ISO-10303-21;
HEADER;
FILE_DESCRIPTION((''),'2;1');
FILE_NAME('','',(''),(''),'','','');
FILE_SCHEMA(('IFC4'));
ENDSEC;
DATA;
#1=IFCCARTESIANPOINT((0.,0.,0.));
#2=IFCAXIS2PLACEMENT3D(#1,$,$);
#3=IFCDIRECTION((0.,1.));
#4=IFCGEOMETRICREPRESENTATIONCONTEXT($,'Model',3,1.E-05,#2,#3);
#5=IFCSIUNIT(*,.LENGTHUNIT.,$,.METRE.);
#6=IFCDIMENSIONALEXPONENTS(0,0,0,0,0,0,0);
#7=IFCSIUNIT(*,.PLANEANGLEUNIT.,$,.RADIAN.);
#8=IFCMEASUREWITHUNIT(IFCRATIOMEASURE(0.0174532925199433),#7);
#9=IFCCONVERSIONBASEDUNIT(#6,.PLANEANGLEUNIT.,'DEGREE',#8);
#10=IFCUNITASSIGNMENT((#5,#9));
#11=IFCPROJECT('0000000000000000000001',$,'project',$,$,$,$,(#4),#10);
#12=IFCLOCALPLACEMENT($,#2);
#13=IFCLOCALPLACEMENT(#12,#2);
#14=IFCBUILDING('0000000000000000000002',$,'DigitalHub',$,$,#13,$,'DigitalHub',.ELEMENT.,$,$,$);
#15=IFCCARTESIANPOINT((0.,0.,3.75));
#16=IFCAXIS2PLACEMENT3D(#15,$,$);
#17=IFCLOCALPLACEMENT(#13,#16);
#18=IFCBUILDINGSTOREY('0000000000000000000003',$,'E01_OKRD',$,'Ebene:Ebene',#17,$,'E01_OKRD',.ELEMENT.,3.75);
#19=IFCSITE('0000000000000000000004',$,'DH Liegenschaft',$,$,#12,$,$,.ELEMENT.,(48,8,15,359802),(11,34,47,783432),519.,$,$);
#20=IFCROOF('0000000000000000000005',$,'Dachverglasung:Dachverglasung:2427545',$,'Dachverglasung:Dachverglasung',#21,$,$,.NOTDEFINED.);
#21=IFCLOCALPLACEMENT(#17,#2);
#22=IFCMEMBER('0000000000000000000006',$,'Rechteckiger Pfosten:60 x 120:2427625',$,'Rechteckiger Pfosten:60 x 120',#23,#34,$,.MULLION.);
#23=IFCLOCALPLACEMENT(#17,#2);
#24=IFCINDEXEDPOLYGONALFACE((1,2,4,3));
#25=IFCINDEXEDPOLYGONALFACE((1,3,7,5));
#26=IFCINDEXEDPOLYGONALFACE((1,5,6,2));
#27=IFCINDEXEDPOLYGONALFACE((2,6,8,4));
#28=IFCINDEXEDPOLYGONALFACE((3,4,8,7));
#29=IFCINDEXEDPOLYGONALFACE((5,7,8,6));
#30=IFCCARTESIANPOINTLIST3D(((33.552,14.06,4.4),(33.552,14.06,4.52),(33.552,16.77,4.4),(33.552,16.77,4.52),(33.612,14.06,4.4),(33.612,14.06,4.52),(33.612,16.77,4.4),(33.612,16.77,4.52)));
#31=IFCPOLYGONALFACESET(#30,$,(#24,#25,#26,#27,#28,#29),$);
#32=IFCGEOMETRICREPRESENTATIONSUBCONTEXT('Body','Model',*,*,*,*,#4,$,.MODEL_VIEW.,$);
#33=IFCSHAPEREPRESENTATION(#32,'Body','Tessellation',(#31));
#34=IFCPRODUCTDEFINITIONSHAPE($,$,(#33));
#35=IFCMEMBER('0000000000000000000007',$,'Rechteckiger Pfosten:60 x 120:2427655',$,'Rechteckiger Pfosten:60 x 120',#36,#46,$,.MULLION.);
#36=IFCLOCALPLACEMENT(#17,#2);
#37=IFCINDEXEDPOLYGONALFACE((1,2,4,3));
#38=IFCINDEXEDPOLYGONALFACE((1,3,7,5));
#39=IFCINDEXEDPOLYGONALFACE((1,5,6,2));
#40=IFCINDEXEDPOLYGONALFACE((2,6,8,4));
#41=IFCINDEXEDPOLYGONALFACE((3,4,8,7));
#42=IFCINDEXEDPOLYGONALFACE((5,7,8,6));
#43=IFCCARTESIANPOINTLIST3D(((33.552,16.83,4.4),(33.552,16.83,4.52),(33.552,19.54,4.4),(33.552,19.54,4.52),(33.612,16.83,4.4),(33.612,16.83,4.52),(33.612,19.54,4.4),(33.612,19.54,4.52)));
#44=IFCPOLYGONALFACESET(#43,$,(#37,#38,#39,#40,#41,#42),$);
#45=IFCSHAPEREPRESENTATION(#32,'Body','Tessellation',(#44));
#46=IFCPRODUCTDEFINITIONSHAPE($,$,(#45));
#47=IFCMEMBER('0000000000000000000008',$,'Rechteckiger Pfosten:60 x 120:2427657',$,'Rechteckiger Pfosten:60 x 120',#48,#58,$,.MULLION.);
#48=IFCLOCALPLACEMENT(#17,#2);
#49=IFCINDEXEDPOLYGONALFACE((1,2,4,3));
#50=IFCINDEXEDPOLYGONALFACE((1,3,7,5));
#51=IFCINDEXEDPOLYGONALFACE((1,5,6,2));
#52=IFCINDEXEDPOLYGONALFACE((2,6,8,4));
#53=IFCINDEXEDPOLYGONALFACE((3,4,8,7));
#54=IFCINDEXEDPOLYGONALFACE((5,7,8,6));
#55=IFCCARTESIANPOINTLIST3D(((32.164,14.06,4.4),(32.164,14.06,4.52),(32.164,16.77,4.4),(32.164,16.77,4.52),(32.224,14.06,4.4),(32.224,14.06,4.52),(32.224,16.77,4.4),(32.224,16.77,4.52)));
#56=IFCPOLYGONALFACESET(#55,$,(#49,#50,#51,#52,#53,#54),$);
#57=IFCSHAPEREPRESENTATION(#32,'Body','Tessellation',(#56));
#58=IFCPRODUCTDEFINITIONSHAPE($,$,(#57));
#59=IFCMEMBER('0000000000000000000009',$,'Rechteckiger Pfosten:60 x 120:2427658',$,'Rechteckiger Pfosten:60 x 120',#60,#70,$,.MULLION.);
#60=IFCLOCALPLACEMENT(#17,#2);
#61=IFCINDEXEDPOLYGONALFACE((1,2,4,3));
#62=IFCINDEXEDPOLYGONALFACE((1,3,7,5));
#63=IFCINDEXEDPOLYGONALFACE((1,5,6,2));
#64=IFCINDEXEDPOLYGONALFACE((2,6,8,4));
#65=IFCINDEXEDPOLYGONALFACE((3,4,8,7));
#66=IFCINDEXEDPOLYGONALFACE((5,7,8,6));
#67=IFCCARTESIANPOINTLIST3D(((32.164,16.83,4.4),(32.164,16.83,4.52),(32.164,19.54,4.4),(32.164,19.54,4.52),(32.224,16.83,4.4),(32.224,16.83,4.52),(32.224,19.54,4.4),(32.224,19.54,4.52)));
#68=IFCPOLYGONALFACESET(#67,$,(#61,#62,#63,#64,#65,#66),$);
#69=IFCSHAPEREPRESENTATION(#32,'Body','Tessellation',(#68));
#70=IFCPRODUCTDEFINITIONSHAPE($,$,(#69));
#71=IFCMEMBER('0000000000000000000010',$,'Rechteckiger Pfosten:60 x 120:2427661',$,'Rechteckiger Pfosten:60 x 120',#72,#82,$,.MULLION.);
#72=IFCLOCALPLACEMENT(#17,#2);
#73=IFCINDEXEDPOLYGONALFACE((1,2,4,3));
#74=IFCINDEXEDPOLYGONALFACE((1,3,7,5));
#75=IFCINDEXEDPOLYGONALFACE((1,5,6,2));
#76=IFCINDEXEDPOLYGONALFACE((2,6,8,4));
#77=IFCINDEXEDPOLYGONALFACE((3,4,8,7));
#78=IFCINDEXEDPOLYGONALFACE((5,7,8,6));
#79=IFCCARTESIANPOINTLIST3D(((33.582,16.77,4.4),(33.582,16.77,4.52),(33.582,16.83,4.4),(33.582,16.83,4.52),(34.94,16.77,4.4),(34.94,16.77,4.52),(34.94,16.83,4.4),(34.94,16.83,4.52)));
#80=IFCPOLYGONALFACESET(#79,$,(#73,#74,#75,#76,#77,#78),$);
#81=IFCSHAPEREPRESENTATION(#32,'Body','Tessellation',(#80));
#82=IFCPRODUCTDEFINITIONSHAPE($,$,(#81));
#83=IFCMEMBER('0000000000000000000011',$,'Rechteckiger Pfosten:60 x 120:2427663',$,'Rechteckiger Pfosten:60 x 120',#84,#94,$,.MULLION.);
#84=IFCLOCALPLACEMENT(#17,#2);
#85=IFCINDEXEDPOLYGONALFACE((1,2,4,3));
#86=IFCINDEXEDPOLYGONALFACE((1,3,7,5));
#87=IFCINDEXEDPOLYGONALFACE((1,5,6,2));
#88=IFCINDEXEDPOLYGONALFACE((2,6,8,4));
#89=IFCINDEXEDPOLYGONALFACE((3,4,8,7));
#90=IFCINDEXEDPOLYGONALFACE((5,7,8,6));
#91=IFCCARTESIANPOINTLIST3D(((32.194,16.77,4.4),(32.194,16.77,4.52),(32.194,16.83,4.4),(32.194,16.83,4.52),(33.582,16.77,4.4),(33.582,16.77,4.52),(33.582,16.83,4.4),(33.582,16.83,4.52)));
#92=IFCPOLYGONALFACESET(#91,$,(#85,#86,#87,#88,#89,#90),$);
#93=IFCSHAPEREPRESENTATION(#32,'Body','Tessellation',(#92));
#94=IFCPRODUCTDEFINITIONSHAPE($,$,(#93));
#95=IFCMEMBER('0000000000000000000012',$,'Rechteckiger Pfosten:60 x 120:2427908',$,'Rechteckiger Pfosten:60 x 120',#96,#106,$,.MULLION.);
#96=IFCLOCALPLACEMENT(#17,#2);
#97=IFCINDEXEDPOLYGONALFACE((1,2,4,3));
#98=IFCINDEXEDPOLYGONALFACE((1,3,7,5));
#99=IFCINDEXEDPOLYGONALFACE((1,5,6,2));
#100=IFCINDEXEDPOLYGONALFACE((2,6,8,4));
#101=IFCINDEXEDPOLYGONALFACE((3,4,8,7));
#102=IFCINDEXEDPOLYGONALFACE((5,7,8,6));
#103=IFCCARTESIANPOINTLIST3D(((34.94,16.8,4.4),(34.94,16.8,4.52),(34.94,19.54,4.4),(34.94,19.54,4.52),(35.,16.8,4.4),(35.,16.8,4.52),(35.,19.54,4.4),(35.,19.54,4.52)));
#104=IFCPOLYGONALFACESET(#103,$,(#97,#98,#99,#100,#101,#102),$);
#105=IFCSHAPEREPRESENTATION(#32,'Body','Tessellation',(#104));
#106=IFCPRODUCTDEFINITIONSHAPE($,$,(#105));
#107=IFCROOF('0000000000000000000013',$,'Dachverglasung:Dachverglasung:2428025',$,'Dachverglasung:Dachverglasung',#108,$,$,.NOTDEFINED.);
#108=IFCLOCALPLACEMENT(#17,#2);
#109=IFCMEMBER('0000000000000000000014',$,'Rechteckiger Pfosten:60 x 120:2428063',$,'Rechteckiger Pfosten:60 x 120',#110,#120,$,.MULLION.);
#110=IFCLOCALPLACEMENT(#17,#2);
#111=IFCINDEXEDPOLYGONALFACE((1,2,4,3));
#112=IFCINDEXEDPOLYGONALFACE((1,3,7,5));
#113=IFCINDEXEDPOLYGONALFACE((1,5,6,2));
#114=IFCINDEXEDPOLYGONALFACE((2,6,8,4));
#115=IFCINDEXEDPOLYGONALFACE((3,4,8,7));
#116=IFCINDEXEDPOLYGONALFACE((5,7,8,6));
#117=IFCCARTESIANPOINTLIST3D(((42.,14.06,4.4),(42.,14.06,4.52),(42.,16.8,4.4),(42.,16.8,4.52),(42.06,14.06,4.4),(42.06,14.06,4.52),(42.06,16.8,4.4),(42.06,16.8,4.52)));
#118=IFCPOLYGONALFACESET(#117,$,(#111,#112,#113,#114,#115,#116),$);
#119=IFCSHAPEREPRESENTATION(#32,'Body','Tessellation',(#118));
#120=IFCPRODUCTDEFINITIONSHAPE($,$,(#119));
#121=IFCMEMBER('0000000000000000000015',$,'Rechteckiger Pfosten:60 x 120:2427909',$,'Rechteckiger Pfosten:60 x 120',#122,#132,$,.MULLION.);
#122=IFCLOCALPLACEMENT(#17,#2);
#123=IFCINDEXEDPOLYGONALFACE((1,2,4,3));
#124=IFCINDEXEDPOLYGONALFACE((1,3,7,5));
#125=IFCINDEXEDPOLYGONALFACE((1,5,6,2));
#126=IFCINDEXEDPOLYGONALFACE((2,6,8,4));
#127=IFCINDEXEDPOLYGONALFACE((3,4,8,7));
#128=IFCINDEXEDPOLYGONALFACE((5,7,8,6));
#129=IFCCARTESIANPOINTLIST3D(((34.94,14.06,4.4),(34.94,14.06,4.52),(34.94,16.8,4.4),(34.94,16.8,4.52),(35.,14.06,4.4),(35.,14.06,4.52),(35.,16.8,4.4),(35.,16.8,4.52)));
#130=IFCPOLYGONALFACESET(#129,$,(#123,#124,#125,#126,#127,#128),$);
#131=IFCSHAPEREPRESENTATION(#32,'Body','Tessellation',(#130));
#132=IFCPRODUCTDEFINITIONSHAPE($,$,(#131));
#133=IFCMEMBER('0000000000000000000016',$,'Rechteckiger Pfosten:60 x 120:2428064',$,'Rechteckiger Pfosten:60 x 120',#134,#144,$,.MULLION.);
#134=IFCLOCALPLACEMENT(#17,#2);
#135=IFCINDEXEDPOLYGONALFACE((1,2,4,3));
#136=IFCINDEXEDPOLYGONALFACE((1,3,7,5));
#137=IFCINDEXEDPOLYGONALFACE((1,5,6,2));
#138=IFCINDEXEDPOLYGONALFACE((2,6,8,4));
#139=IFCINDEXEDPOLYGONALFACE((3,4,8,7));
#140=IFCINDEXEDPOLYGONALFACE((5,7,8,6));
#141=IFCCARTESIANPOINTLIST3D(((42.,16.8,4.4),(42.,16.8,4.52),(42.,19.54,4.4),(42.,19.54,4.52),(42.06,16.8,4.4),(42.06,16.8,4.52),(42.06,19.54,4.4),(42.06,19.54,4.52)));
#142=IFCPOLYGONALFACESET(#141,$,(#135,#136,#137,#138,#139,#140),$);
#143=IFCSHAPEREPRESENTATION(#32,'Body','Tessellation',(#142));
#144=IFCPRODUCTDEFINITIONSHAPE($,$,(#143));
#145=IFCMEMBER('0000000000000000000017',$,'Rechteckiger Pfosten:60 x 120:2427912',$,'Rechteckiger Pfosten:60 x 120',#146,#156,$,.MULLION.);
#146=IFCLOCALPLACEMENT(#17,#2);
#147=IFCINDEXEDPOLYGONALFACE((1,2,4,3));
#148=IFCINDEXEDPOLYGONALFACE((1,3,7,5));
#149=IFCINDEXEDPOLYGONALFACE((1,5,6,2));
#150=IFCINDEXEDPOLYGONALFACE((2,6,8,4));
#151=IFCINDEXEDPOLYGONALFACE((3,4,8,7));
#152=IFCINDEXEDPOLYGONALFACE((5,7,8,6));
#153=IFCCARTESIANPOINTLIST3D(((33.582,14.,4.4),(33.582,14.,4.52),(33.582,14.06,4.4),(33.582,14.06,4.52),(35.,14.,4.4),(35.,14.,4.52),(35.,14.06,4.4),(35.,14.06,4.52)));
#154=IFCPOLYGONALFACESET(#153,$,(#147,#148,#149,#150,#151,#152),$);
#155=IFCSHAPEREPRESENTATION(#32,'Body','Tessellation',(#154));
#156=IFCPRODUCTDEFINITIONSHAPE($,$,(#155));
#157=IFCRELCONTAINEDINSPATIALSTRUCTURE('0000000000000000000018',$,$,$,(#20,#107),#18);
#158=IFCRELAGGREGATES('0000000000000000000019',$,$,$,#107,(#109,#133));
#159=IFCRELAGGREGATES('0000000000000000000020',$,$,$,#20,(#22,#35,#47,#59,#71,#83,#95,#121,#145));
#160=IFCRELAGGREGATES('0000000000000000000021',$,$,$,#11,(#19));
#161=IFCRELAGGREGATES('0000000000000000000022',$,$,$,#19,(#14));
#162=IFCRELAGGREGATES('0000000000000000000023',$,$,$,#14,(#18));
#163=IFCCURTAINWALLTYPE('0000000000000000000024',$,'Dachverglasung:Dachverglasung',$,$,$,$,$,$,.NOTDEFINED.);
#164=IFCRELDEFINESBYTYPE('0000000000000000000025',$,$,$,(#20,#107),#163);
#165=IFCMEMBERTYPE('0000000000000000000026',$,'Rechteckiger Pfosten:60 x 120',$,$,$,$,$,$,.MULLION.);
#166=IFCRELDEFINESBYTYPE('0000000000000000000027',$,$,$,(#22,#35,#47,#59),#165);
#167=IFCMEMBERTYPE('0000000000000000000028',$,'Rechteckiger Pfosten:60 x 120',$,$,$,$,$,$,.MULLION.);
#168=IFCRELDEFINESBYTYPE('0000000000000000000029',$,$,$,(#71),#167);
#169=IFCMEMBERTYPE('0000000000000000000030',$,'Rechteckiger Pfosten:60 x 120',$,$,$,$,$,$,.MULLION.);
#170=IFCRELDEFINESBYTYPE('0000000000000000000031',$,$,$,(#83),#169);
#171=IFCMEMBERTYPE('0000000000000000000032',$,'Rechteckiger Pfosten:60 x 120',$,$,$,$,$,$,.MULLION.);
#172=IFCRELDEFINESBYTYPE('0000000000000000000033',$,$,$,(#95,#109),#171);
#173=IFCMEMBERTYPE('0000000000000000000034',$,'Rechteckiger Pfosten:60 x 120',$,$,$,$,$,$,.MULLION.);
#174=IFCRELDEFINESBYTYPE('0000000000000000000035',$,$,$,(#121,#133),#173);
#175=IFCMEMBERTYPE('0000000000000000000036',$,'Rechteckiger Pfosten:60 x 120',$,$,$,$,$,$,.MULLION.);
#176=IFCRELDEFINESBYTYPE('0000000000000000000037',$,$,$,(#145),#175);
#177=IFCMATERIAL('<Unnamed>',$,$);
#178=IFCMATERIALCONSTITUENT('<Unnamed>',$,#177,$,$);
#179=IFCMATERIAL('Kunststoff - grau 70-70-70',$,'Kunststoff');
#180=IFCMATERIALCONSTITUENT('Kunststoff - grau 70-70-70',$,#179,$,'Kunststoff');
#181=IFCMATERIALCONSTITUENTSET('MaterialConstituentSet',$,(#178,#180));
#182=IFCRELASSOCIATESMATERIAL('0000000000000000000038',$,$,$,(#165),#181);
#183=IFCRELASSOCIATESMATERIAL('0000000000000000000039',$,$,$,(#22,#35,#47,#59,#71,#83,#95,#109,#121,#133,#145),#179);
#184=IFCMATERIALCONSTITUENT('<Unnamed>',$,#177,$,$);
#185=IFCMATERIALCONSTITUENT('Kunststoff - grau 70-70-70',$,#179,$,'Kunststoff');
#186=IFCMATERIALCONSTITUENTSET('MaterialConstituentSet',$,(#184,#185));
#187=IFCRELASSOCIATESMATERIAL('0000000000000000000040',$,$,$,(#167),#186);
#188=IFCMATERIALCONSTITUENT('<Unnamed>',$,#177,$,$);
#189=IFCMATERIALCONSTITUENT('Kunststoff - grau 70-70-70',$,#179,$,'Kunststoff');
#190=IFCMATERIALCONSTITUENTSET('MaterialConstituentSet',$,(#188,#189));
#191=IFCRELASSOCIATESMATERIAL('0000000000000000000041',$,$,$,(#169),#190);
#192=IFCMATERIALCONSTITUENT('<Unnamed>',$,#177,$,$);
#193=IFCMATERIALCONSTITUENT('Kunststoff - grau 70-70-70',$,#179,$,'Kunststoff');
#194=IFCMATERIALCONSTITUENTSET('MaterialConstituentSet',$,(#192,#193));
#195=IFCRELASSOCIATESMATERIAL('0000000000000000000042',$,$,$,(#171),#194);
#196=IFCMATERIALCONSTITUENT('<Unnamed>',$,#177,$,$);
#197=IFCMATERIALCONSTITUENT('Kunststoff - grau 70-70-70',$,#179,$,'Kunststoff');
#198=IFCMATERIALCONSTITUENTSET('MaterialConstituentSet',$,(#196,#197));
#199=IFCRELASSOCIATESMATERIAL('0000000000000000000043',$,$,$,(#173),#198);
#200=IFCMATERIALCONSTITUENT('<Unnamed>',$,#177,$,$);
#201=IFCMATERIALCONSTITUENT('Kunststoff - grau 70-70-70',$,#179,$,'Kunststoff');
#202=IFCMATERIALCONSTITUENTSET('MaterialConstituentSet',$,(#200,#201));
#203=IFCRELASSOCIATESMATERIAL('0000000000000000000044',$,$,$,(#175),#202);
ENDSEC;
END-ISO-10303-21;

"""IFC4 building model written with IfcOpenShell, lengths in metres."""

from ifc_helpers import new_model, entity, si_unit, converted_unit, direction, frame, origin, place, context, subcontext, project, spatial, indexed_curve, outline, extrude, source, transform, mapped, material, constituent, constituent_set, type_object, type_shapes, element, aggregate, save


model = new_model("IFC4")

# Units and contexts
model_context = context("Model", 3, precision=1e-05, world=origin(), true_north=direction((0.0, 1.0)))
body_context = subcontext(model_context, "Body", "Model", "MODEL_VIEW")
ifc_project = project(units=[si_unit("LENGTHUNIT", "METRE"), converted_unit("PLANEANGLEUNIT", "DEGREE", entity("IfcRatioMeasure", 0.0174532925199433), si_unit("PLANEANGLEUNIT", "RADIAN"), dimensions=[0, 0, 0, 0, 0, 0, 0])], contexts=[model_context])

# Site, building, storey
site_placement = place(None, frame((0.0, 0.0, 0.0)))
site = spatial("IfcSite", under=ifc_project, at=site_placement, Name="DH Liegenschaft", CompositionType="ELEMENT", RefLatitude=(48, 8, 15, 359802), RefLongitude=(11, 34, 47, 783432), RefElevation=519.0)
building_placement = place(site_placement, origin())
building = spatial("IfcBuilding", under=site, at=building_placement, Name="DigitalHub", LongName="DigitalHub", CompositionType="ELEMENT")
storey_placement = place(building_placement, frame((0.0, 0.0, 3.75)))
storey = spatial("IfcBuildingStorey", under=building, at=storey_placement, Name="E01_OKRD", ObjectType="Ebene:Ebene", LongName="E01_OKRD", CompositionType="ELEMENT", Elevation=3.75)

# Roof, members
curtain_wall_type = type_object("IfcCurtainWallType", Name="Dachverglasung:Dachverglasung", PredefinedType="NOTDEFINED")
roof_1_placement = place(storey_placement, frame((0.0, 0.0, -3.75)))
roof_1 = element("IfcRoof", 1, at=roof_1_placement, inside=storey, type_object=curtain_wall_type, Name="Dachverglasung:Dachverglasung:2427545", ObjectType="Dachverglasung:Dachverglasung", PredefinedType="NOTDEFINED")
ifc_material_1 = material(Name="Kunststoff - grau 70-70-70", Category="Kunststoff")
ifc_material_2 = material(Name="<Unnamed>")
ifc_constituent_1 = constituent(ifc_material_2, Name="<Unnamed>")
ifc_constituent_2 = constituent(ifc_material_1, Name="Kunststoff - grau 70-70-70", Category="Kunststoff")
ifc_constituent_set_1 = constituent_set(constituents=[ifc_constituent_1, ifc_constituent_2], Name="MaterialConstituentSet")
member_type_1 = type_object("IfcMemberType", Name="Rechteckiger Pfosten:60 x 120", PredefinedType="MULLION", material=ifc_constituent_set_1)
shared_shape_1 = source(origin(), body_context, "Body", "SweptSolid", [
    extrude(outline(indexed_curve([(-0.06, -0.03), (0.06, -0.03), (0.06, 0.03), (-0.06, 0.03), (-0.06, -0.03)], self_intersect=False)), frame((0.0, 0.0, -2.71), z_axis=(0.0, 0.0, 1.0), x_axis=(0.0, -1.0, 0.0)), (0.0, 0.0, 1.0), 2.71),
])
type_shapes(member_type_1, [shared_shape_1])
member_1_placement = place(storey_placement, frame((33.582, 14.06, 4.46), z_axis=(0.0, -1.0, 0.0), x_axis=(-1.0, 0.0, 0.0)))
member_1 = element("IfcMember", 2, at=member_1_placement, type_object=member_type_1, material=ifc_material_1, Name="Rechteckiger Pfosten:60 x 120:2427625", ObjectType="Rechteckiger Pfosten:60 x 120", PredefinedType="MULLION", context=body_context, shape_type="MappedRepresentation", body=[
    mapped(shared_shape_1, transform((0.0, 0.0, 0.0), scale=1.0)),
])
member_2_placement = place(storey_placement, frame((33.582, 16.83, 4.46), z_axis=(0.0, -1.0, 0.0), x_axis=(-1.0, 0.0, 0.0)))
member_2 = element("IfcMember", 3, at=member_2_placement, type_object=member_type_1, material=ifc_material_1, Name="Rechteckiger Pfosten:60 x 120:2427655", ObjectType="Rechteckiger Pfosten:60 x 120", PredefinedType="MULLION", context=body_context, shape_type="MappedRepresentation", body=[
    mapped(shared_shape_1, transform((0.0, 0.0, 0.0), scale=1.0)),
])
member_3_placement = place(storey_placement, frame((32.194, 14.06, 4.46), z_axis=(0.0, -1.0, 0.0), x_axis=(-1.0, 0.0, 0.0)))
member_3 = element("IfcMember", 4, at=member_3_placement, type_object=member_type_1, material=ifc_material_1, Name="Rechteckiger Pfosten:60 x 120:2427657", ObjectType="Rechteckiger Pfosten:60 x 120", PredefinedType="MULLION", context=body_context, shape_type="MappedRepresentation", body=[
    mapped(shared_shape_1, transform((0.0, 0.0, 0.0), scale=1.0)),
])
member_4_placement = place(storey_placement, frame((32.194, 16.83, 4.46), z_axis=(0.0, -1.0, 0.0), x_axis=(-1.0, 0.0, 0.0)))
member_4 = element("IfcMember", 5, at=member_4_placement, type_object=member_type_1, material=ifc_material_1, Name="Rechteckiger Pfosten:60 x 120:2427658", ObjectType="Rechteckiger Pfosten:60 x 120", PredefinedType="MULLION", context=body_context, shape_type="MappedRepresentation", body=[
    mapped(shared_shape_1, transform((0.0, 0.0, 0.0), scale=1.0)),
])
ifc_constituent_3 = constituent(ifc_material_2, Name="<Unnamed>")
ifc_constituent_4 = constituent(ifc_material_1, Name="Kunststoff - grau 70-70-70", Category="Kunststoff")
ifc_constituent_set_2 = constituent_set(constituents=[ifc_constituent_3, ifc_constituent_4], Name="MaterialConstituentSet")
member_type_2 = type_object("IfcMemberType", Name="Rechteckiger Pfosten:60 x 120", PredefinedType="MULLION", material=ifc_constituent_set_2)
shared_shape_2 = source(origin(), body_context, "Body", "SweptSolid", [
    extrude(outline(indexed_curve([(-0.06, -0.03), (0.06, -0.03), (0.06, 0.03), (-0.06, 0.03), (-0.06, -0.03)], self_intersect=False)), frame((0.0, 0.0, -1.358), z_axis=(0.0, 0.0, 1.0), x_axis=(0.0, -1.0, 0.0)), (0.0, 0.0, 1.0), 1.358),
])
type_shapes(member_type_2, [shared_shape_2])
member_5_placement = place(storey_placement, frame((33.582, 16.8, 4.46), z_axis=(-1.0, 0.0, 0.0), x_axis=(0.0, 1.0, 0.0)))
member_5 = element("IfcMember", 6, at=member_5_placement, type_object=member_type_2, material=ifc_material_1, Name="Rechteckiger Pfosten:60 x 120:2427661", ObjectType="Rechteckiger Pfosten:60 x 120", PredefinedType="MULLION", context=body_context, shape_type="MappedRepresentation", body=[
    mapped(shared_shape_2, transform((0.0, 0.0, 0.0), scale=1.0)),
])
ifc_constituent_5 = constituent(ifc_material_2, Name="<Unnamed>")
ifc_constituent_6 = constituent(ifc_material_1, Name="Kunststoff - grau 70-70-70", Category="Kunststoff")
ifc_constituent_set_3 = constituent_set(constituents=[ifc_constituent_5, ifc_constituent_6], Name="MaterialConstituentSet")
member_type_3 = type_object("IfcMemberType", Name="Rechteckiger Pfosten:60 x 120", PredefinedType="MULLION", material=ifc_constituent_set_3)
shared_shape_3 = source(origin(), body_context, "Body", "SweptSolid", [
    extrude(outline(indexed_curve([(-0.06, -0.03), (0.06, -0.03), (0.06, 0.03), (-0.06, 0.03), (-0.06, -0.03)], self_intersect=False)), frame((0.0, 0.0, -1.388), z_axis=(0.0, 0.0, 1.0), x_axis=(0.0, -1.0, 0.0)), (0.0, 0.0, 1.0), 1.388),
])
type_shapes(member_type_3, [shared_shape_3])
member_6_placement = place(storey_placement, frame((32.194, 16.8, 4.46), z_axis=(-1.0, 0.0, 0.0), x_axis=(0.0, 1.0, 0.0)))
member_6 = element("IfcMember", 7, at=member_6_placement, type_object=member_type_3, material=ifc_material_1, Name="Rechteckiger Pfosten:60 x 120:2427663", ObjectType="Rechteckiger Pfosten:60 x 120", PredefinedType="MULLION", context=body_context, shape_type="MappedRepresentation", body=[
    mapped(shared_shape_3, transform((0.0, 0.0, 0.0), scale=1.0)),
])
ifc_constituent_7 = constituent(ifc_material_2, Name="<Unnamed>")
ifc_constituent_8 = constituent(ifc_material_1, Name="Kunststoff - grau 70-70-70", Category="Kunststoff")
ifc_constituent_set_4 = constituent_set(constituents=[ifc_constituent_7, ifc_constituent_8], Name="MaterialConstituentSet")
member_type_4 = type_object("IfcMemberType", Name="Rechteckiger Pfosten:60 x 120", PredefinedType="MULLION", material=ifc_constituent_set_4)
shared_shape_4 = source(origin(), body_context, "Body", "SweptSolid", [
    extrude(outline(indexed_curve([(-0.06, -0.03), (0.06, -0.03), (0.06, 0.03), (-0.06, 0.03), (-0.06, -0.03)], self_intersect=False)), frame((-0.03, 0.0, -2.74), z_axis=(0.0, 0.0, 1.0), x_axis=(0.0, -1.0, 0.0)), (0.0, 0.0, 1.0), 2.74),
])
type_shapes(member_type_4, [shared_shape_4])
member_7_placement = place(storey_placement, frame((35.0, 19.54, 4.46), z_axis=(0.0, 1.0, 0.0), x_axis=(1.0, 0.0, 0.0)))
member_7 = element("IfcMember", 8, at=member_7_placement, type_object=member_type_4, material=ifc_material_1, Name="Rechteckiger Pfosten:60 x 120:2427908", ObjectType="Rechteckiger Pfosten:60 x 120", PredefinedType="MULLION", context=body_context, shape_type="MappedRepresentation", body=[
    mapped(shared_shape_4, transform((0.0, 0.0, 0.0), scale=1.0)),
])

# Roof, member
roof_2_placement = place(storey_placement, frame((0.0, 0.0, -3.75)))
roof_2 = element("IfcRoof", 9, at=roof_2_placement, inside=storey, type_object=curtain_wall_type, Name="Dachverglasung:Dachverglasung:2428025", ObjectType="Dachverglasung:Dachverglasung", PredefinedType="NOTDEFINED")
member_8_placement = place(storey_placement, frame((42.0, 14.06, 4.46), z_axis=(0.0, -1.0, 0.0), x_axis=(-1.0, 0.0, 0.0)))
member_8 = element("IfcMember", 10, at=member_8_placement, type_object=member_type_4, material=ifc_material_1, Name="Rechteckiger Pfosten:60 x 120:2428063", ObjectType="Rechteckiger Pfosten:60 x 120", PredefinedType="MULLION", context=body_context, shape_type="MappedRepresentation", body=[
    mapped(shared_shape_4, transform((0.0, 0.0, 0.0), scale=1.0)),
])

# Members
ifc_constituent_9 = constituent(ifc_material_2, Name="<Unnamed>")
ifc_constituent_10 = constituent(ifc_material_1, Name="Kunststoff - grau 70-70-70", Category="Kunststoff")
ifc_constituent_set_5 = constituent_set(constituents=[ifc_constituent_9, ifc_constituent_10], Name="MaterialConstituentSet")
member_type_5 = type_object("IfcMemberType", Name="Rechteckiger Pfosten:60 x 120", PredefinedType="MULLION", material=ifc_constituent_set_5)
shared_shape_5 = source(origin(), body_context, "Body", "SweptSolid", [
    extrude(outline(indexed_curve([(-0.06, -0.03), (0.06, -0.03), (0.06, 0.03), (-0.06, 0.03), (-0.06, -0.03)], self_intersect=False)), frame((-0.03, 0.0, -2.74), z_axis=(0.0, 0.0, 1.0), x_axis=(0.0, -1.0, 0.0)), (0.0, 0.0, 1.0), 2.74),
])
type_shapes(member_type_5, [shared_shape_5])
member_9_placement = place(storey_placement, frame((35.0, 16.8, 4.46), z_axis=(0.0, 1.0, 0.0), x_axis=(1.0, 0.0, 0.0)))
member_9 = element("IfcMember", 11, at=member_9_placement, type_object=member_type_5, material=ifc_material_1, Name="Rechteckiger Pfosten:60 x 120:2427909", ObjectType="Rechteckiger Pfosten:60 x 120", PredefinedType="MULLION", context=body_context, shape_type="MappedRepresentation", body=[
    mapped(shared_shape_5, transform((0.0, 0.0, 0.0), scale=1.0)),
])
member_10_placement = place(storey_placement, frame((42.0, 16.8, 4.46), z_axis=(0.0, -1.0, 0.0), x_axis=(-1.0, 0.0, 0.0)))
member_10 = element("IfcMember", 12, at=member_10_placement, type_object=member_type_5, material=ifc_material_1, Name="Rechteckiger Pfosten:60 x 120:2428064", ObjectType="Rechteckiger Pfosten:60 x 120", PredefinedType="MULLION", context=body_context, shape_type="MappedRepresentation", body=[
    mapped(shared_shape_5, transform((0.0, 0.0, 0.0), scale=1.0)),
])
ifc_constituent_11 = constituent(ifc_material_2, Name="<Unnamed>")
ifc_constituent_12 = constituent(ifc_material_1, Name="Kunststoff - grau 70-70-70", Category="Kunststoff")
ifc_constituent_set_6 = constituent_set(constituents=[ifc_constituent_11, ifc_constituent_12], Name="MaterialConstituentSet")
member_type_6 = type_object("IfcMemberType", Name="Rechteckiger Pfosten:60 x 120", PredefinedType="MULLION", material=ifc_constituent_set_6)
shared_shape_6 = source(origin(), body_context, "Body", "SweptSolid", [
    extrude(outline(indexed_curve([(-0.06, -0.03), (0.06, -0.03), (0.06, 0.03), (-0.06, 0.03), (-0.06, -0.03)], self_intersect=False)), frame((-0.03, 0.0, -1.418), z_axis=(0.0, 0.0, 1.0), x_axis=(0.0, -1.0, 0.0)), (0.0, 0.0, 1.0), 1.418),
])
type_shapes(member_type_6, [shared_shape_6])
member_11_placement = place(storey_placement, frame((35.0, 14.0, 4.46), z_axis=(1.0, 0.0, 0.0), x_axis=(0.0, -1.0, 0.0)))
member_11 = element("IfcMember", 13, at=member_11_placement, type_object=member_type_6, material=ifc_material_1, Name="Rechteckiger Pfosten:60 x 120:2427912", ObjectType="Rechteckiger Pfosten:60 x 120", PredefinedType="MULLION", context=body_context, shape_type="MappedRepresentation", body=[
    mapped(shared_shape_6, transform((0.0, 0.0, 0.0), scale=1.0)),
])
aggregate(roof_2, [member_8, member_10])

aggregate(roof_1, [member_1, member_2, member_3, member_4, member_5, member_6, member_7, member_9, member_11])

save(model, "model.ifc")
